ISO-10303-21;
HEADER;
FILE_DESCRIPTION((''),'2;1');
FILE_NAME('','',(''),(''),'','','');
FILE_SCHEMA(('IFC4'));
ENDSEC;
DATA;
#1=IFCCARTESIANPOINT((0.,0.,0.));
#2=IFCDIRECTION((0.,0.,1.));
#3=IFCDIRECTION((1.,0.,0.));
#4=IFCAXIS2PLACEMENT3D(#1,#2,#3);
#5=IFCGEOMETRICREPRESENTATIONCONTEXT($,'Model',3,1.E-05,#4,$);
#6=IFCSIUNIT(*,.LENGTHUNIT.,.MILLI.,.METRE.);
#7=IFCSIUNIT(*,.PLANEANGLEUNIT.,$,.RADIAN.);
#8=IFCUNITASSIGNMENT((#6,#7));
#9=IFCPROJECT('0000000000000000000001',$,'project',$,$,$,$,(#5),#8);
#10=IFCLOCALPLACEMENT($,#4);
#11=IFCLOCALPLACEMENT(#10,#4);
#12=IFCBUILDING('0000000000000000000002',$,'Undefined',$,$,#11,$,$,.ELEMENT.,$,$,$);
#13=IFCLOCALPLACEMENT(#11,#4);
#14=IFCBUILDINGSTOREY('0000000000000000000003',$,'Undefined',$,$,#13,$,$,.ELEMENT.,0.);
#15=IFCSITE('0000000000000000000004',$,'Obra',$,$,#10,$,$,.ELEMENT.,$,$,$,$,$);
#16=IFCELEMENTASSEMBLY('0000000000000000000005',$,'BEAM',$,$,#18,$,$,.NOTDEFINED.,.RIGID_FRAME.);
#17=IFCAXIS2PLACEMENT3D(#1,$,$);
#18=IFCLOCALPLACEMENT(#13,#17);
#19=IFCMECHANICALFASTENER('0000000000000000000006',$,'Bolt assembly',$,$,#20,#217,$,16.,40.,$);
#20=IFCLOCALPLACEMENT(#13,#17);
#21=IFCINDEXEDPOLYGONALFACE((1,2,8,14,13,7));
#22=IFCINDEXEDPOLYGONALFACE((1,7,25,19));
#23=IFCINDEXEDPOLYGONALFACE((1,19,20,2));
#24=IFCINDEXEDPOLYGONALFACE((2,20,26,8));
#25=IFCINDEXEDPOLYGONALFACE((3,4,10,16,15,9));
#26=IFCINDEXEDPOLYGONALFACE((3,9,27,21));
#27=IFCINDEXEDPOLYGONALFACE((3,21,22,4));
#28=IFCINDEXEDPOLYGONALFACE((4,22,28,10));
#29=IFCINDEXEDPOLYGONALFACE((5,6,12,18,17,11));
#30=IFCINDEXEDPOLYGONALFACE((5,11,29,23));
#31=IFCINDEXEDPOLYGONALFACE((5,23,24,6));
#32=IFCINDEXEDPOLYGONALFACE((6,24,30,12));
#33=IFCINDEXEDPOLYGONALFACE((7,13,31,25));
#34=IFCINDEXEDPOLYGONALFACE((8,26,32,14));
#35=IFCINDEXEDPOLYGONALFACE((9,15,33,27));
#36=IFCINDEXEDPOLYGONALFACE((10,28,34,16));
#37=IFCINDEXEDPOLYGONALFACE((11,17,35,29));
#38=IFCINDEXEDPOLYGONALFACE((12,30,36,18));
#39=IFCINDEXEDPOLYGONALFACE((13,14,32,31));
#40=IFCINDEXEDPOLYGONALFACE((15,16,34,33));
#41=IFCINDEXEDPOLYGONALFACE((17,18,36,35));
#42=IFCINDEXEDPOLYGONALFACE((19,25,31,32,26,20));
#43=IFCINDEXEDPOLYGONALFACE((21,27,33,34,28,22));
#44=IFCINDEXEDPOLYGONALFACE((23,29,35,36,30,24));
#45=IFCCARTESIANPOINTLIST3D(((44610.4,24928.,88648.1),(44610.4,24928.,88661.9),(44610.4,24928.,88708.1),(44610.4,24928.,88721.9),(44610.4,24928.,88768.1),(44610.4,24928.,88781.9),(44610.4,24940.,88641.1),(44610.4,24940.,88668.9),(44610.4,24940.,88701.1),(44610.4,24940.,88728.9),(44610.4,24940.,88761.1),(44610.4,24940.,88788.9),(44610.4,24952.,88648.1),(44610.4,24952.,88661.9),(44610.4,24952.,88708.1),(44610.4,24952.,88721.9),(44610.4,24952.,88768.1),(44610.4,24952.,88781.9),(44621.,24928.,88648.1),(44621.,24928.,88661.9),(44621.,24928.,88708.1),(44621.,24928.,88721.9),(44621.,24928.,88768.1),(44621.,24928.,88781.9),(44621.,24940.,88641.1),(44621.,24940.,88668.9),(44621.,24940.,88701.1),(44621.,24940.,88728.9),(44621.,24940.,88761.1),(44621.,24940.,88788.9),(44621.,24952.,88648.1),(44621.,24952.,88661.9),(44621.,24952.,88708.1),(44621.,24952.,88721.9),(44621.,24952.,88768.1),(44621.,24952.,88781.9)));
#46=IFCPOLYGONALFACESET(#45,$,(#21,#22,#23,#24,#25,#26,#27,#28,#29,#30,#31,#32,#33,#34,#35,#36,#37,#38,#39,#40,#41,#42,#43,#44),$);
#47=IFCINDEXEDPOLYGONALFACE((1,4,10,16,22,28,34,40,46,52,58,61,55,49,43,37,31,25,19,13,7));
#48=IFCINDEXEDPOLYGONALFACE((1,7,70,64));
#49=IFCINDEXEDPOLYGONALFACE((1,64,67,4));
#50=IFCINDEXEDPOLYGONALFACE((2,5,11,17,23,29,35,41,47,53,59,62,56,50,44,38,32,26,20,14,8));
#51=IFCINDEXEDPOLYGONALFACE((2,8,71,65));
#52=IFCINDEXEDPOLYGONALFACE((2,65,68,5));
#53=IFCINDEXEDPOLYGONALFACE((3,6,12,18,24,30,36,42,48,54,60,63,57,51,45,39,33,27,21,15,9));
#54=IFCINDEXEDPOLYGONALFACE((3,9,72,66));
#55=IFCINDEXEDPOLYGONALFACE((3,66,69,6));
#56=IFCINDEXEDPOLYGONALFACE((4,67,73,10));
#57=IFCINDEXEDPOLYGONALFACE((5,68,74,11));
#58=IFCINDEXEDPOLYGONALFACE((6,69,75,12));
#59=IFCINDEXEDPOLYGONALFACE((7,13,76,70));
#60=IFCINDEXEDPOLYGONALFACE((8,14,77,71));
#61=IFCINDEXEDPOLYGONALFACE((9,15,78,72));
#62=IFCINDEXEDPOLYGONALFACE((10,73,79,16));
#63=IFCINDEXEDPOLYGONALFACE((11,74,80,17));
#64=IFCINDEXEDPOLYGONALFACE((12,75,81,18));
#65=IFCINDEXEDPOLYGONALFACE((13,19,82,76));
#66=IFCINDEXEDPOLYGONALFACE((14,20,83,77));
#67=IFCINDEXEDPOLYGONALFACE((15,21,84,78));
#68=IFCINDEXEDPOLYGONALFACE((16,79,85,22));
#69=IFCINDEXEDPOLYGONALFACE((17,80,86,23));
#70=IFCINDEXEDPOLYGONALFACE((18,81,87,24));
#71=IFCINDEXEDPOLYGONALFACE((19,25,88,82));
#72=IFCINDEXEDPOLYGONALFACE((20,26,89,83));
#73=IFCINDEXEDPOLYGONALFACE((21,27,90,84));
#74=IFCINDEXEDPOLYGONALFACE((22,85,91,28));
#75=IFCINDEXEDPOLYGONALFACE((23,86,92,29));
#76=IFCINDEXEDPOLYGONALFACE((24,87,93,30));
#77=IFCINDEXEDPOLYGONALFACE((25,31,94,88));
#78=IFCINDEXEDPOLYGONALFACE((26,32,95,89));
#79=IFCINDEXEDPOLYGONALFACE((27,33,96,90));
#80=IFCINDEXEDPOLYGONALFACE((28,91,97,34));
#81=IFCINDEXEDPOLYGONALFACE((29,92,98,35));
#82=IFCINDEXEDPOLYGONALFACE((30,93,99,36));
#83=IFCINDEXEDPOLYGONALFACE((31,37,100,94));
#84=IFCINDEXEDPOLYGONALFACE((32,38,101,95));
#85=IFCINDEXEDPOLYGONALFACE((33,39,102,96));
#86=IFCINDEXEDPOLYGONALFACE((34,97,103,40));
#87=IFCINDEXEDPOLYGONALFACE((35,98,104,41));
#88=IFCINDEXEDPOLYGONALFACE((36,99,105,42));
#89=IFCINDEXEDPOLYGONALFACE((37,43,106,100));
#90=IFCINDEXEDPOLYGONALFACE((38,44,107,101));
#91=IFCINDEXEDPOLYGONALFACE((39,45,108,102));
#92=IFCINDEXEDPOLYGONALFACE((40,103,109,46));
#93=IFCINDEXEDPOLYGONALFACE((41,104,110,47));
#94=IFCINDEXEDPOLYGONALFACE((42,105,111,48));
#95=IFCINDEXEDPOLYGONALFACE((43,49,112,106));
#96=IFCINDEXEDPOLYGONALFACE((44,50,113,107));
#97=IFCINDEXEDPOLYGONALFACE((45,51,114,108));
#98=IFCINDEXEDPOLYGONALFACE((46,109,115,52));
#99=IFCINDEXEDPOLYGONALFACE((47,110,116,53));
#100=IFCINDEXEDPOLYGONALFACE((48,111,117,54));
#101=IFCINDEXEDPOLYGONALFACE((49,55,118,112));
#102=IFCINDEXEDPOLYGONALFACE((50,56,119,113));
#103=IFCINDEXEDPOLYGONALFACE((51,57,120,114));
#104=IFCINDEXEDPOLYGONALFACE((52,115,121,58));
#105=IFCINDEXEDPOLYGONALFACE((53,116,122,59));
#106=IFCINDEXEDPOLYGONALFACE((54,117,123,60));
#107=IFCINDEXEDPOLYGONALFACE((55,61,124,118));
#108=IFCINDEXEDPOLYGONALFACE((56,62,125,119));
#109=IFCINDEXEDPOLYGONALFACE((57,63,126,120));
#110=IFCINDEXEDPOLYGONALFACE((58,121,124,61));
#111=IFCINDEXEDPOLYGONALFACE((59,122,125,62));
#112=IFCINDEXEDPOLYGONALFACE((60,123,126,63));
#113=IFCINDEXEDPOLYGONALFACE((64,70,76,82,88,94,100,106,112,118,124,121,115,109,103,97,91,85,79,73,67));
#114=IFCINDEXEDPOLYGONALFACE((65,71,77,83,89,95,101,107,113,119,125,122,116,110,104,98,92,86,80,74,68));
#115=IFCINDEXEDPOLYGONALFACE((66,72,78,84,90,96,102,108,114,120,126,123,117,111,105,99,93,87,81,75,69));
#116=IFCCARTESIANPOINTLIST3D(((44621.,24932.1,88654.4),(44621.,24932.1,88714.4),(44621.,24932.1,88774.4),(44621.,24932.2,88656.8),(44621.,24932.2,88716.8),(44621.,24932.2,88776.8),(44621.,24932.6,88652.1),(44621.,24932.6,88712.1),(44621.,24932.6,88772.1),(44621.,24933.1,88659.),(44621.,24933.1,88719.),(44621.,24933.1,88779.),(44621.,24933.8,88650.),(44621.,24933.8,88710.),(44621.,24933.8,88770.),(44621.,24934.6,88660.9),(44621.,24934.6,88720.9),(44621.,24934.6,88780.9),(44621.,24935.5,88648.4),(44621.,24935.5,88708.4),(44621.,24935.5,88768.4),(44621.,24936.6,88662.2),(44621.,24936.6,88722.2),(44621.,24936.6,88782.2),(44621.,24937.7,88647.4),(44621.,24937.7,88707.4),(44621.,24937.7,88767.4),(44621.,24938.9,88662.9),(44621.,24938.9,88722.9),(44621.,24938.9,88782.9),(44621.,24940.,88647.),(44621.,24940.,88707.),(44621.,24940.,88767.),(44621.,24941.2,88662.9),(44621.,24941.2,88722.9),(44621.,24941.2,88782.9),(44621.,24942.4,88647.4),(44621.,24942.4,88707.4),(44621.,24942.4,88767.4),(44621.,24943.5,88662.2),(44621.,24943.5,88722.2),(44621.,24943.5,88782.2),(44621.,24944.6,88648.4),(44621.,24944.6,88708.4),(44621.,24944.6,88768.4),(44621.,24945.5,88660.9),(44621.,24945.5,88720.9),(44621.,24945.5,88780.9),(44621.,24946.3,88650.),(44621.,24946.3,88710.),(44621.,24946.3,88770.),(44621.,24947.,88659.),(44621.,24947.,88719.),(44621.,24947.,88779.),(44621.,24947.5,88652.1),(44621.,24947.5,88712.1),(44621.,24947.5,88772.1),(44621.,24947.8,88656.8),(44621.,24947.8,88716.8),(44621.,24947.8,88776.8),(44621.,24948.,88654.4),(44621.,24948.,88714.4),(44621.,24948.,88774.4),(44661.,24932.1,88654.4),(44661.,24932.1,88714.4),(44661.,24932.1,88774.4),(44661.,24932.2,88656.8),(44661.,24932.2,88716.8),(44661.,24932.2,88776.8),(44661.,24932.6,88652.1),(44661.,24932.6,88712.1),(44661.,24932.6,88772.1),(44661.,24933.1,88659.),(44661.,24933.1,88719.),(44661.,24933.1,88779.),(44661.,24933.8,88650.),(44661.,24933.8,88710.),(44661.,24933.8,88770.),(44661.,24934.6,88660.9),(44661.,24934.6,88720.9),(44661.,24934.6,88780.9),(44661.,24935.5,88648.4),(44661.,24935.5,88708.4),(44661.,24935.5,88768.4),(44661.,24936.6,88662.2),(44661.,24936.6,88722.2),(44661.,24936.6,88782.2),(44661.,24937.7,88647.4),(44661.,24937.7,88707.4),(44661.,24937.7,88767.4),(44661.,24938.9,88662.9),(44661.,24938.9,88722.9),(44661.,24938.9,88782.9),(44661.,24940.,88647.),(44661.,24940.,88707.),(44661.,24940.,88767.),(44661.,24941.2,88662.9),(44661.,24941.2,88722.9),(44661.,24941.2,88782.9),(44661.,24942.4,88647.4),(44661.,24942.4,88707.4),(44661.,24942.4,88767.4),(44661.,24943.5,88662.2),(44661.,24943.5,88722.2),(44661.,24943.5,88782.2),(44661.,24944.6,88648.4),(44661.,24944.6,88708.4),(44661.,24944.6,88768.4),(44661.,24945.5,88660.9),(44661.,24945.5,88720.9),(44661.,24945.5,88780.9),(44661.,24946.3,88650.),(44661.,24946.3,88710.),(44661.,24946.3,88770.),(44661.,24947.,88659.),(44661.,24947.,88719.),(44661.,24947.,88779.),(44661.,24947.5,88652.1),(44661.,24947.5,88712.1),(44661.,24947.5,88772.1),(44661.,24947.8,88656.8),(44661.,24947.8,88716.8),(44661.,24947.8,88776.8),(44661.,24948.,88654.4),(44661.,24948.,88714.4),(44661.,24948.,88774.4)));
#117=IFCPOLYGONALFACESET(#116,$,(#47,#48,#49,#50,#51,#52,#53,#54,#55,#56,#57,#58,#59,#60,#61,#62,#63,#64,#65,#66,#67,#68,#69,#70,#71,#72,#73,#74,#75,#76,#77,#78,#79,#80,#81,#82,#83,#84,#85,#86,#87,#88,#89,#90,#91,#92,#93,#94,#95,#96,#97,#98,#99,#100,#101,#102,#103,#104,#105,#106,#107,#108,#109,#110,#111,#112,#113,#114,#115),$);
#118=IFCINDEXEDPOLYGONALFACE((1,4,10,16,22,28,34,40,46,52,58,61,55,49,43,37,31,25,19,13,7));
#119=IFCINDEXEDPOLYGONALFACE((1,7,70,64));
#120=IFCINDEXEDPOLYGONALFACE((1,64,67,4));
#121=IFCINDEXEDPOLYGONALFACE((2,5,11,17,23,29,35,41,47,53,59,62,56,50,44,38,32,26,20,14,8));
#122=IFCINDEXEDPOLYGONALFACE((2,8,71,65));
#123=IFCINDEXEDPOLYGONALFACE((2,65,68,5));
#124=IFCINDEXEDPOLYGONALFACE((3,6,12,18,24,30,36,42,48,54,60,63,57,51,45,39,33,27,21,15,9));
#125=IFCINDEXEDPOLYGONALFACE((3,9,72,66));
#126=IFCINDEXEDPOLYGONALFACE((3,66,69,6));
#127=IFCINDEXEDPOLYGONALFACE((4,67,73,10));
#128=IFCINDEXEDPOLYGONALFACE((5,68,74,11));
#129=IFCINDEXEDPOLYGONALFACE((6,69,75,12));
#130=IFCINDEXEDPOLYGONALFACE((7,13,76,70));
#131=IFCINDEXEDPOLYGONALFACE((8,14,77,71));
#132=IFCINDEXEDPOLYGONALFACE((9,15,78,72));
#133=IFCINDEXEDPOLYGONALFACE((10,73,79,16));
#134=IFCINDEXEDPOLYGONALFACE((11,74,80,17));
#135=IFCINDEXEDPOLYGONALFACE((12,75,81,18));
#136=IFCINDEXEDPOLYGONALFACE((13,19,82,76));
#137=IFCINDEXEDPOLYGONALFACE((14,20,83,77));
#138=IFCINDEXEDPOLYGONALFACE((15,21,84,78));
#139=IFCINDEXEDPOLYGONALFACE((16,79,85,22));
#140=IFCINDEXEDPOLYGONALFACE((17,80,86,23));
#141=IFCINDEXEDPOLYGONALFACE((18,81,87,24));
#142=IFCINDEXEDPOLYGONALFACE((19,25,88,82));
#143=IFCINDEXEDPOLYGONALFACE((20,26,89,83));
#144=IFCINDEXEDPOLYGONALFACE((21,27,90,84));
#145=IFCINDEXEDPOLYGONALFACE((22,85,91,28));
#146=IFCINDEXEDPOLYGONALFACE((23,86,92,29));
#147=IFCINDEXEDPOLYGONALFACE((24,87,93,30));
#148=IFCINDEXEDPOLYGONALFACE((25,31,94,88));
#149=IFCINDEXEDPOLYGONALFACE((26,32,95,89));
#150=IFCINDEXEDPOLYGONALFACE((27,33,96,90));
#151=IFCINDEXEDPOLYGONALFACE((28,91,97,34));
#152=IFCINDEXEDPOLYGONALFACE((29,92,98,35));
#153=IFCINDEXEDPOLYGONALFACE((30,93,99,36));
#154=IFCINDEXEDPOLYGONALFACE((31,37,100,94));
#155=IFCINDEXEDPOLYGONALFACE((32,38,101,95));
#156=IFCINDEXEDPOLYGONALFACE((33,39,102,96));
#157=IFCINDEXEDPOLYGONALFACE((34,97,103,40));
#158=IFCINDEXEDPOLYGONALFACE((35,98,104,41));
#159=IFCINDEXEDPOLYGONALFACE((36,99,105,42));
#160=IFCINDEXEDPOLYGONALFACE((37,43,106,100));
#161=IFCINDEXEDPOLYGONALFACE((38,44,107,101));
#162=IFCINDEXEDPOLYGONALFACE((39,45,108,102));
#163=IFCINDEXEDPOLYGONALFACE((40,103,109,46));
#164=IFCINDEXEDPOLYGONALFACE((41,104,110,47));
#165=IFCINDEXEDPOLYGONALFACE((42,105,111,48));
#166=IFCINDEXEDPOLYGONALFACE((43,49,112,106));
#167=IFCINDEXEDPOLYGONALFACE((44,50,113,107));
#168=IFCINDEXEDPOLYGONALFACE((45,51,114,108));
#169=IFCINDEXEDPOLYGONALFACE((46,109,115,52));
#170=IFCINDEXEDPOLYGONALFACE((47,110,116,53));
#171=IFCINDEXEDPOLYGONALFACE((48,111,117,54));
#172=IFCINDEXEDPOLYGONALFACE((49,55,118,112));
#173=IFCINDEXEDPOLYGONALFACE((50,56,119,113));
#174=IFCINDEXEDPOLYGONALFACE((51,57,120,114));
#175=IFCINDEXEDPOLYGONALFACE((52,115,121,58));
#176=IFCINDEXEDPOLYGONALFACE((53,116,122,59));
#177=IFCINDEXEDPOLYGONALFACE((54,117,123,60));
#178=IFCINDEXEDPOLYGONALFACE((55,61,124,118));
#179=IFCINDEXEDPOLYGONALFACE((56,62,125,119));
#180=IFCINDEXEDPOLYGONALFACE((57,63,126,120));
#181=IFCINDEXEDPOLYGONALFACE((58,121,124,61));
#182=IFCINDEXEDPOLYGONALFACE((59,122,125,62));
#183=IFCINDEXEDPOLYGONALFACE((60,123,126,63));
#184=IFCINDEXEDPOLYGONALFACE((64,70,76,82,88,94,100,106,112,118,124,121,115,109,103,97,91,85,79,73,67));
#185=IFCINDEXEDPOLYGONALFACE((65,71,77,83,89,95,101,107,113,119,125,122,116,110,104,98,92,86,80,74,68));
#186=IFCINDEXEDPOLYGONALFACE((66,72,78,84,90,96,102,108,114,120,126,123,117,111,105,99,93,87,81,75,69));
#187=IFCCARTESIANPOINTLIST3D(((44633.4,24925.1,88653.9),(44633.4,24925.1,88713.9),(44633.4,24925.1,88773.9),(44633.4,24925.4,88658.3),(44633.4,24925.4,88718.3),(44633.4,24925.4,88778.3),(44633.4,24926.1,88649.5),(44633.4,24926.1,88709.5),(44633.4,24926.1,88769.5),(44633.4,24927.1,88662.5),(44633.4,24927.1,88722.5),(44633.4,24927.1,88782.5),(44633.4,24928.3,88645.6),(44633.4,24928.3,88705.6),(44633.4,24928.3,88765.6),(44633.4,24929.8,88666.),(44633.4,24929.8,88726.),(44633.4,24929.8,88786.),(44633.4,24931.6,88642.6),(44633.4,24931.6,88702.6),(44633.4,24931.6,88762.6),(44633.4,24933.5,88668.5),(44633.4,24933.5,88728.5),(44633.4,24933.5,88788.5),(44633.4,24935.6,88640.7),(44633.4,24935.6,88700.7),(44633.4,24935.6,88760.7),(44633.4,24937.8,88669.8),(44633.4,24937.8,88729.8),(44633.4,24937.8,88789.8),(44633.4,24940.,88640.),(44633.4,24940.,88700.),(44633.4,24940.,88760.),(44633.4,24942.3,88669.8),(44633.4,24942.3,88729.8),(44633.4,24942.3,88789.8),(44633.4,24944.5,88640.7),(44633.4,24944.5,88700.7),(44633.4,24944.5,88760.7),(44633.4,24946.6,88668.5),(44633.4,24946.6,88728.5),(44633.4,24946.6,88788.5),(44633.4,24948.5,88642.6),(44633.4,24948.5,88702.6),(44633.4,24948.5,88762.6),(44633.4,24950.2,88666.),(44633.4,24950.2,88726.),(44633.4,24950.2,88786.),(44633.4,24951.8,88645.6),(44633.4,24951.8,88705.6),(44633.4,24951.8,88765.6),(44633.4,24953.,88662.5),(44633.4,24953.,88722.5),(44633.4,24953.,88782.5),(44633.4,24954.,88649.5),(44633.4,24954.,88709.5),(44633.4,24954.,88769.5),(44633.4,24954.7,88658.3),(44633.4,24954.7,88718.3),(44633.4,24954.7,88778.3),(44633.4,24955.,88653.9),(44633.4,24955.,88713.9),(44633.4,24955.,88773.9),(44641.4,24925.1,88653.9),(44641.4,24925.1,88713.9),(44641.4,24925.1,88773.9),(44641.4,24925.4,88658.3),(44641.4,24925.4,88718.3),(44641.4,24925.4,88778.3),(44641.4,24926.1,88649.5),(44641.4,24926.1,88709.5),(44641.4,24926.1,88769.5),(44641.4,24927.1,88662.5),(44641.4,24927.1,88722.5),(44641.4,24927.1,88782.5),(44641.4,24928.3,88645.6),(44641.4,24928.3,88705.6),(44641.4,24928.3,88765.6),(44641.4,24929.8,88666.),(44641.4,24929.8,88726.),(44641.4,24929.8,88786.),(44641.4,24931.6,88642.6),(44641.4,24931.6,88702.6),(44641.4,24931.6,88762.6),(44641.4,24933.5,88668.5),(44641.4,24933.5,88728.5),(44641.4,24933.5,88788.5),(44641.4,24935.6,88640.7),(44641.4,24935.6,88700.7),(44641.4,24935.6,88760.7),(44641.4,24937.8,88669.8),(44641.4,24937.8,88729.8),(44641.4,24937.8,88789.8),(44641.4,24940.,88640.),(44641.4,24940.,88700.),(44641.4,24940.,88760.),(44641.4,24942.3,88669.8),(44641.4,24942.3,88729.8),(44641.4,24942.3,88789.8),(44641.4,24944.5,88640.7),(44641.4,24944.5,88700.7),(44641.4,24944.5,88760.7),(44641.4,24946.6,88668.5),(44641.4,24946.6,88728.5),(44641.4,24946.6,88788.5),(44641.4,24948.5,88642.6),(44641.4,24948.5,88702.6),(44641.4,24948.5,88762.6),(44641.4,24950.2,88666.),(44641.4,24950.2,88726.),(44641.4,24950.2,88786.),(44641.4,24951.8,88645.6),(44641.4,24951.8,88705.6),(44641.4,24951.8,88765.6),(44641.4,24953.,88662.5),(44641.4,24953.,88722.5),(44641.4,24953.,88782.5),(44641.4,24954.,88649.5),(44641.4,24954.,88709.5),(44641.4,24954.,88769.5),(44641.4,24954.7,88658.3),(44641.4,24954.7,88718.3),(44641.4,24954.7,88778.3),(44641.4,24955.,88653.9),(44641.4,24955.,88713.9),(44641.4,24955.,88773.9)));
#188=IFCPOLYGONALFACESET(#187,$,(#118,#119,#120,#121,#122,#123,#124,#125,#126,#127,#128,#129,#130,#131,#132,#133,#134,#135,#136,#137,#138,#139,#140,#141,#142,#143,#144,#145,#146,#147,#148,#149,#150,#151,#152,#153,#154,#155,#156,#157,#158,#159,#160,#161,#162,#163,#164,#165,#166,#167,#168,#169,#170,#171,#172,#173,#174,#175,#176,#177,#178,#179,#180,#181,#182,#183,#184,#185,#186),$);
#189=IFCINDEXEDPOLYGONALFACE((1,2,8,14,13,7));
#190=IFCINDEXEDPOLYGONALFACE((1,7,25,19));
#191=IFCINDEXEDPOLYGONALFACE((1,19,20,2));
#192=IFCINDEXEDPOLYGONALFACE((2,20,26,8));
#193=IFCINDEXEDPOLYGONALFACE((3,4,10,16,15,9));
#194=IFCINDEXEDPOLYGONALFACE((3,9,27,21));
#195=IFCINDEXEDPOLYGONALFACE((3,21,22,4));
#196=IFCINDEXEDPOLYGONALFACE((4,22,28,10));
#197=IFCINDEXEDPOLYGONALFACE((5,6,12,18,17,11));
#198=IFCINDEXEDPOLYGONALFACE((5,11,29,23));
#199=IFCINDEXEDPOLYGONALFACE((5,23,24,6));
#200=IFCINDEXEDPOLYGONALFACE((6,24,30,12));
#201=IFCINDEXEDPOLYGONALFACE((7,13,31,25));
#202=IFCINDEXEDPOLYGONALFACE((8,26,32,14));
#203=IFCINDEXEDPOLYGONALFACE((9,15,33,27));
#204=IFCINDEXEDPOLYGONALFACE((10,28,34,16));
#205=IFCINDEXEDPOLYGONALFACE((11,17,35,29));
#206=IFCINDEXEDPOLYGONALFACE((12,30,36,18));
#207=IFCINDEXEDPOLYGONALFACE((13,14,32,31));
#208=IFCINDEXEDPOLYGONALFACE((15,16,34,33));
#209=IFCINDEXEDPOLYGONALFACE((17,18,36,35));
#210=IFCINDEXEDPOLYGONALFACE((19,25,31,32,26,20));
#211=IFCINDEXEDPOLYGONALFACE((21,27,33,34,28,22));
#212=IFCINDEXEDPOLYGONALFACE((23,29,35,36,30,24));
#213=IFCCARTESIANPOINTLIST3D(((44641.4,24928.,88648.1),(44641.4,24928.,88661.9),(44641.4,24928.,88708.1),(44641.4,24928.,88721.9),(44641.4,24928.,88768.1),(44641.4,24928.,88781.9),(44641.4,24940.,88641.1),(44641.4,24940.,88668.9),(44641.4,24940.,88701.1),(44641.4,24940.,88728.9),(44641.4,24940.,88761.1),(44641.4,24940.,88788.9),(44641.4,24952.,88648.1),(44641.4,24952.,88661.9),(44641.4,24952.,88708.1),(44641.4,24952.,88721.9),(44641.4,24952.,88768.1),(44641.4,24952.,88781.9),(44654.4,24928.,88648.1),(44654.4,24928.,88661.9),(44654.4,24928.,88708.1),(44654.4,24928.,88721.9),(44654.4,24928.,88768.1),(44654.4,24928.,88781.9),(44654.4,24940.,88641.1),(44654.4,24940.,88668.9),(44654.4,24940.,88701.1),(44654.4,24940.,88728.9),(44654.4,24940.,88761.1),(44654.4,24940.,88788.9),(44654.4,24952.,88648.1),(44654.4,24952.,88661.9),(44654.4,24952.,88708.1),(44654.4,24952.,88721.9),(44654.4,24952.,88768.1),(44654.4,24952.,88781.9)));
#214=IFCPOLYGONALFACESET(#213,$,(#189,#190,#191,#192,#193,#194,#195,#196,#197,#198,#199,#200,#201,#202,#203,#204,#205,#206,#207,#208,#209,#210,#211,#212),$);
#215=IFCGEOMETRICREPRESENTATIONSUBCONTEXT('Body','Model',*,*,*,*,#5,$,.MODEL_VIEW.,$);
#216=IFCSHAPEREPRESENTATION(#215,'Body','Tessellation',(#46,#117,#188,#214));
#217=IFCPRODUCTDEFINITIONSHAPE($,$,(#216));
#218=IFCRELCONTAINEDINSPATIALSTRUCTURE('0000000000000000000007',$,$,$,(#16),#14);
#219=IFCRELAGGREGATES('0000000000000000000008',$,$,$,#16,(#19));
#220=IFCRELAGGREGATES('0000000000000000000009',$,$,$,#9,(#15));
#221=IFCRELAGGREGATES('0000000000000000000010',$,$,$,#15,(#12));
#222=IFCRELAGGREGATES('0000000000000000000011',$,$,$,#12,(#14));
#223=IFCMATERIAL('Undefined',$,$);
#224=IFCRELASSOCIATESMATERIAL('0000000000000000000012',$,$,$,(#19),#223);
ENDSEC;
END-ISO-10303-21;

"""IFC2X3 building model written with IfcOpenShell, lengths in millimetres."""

from ifc_helpers import new_model, si_unit, frame, origin_with_axes, origin_2d_with_axis, place, context, subcontext, project, spatial, polyline, circle, outline, extrude, source, transform, mapped, material, element, aggregate, save


model = new_model("IFC2X3")

# Units and contexts
model_context = context("Model", 3, precision=1e-05, world=origin_with_axes())
body_context = subcontext(model_context, "Body", "Model", "MODEL_VIEW")
ifc_project = project(units=[si_unit("LENGTHUNIT", "METRE", prefix="MILLI"), si_unit("PLANEANGLEUNIT", "RADIAN")], contexts=[model_context])

# Site, building, storey
site_placement = place(None, origin_with_axes())
site = spatial("IfcSite", under=ifc_project, at=site_placement, Name="Obra", CompositionType="ELEMENT")
building_placement = place(site_placement, origin_with_axes())
building = spatial("IfcBuilding", under=site, at=building_placement, Name="Undefined", CompositionType="ELEMENT")
storey_placement = place(building_placement, origin_with_axes())
storey = spatial("IfcBuildingStorey", under=building, at=storey_placement, Name="Undefined", CompositionType="ELEMENT", Elevation=0.0)

# Element assembly
ifc_material_1 = material(Name="Undefined")
assembly_1_placement = place(storey_placement, origin_with_axes())
assembly_1 = element("IfcElementAssembly", 1, at=assembly_1_placement, inside=storey, Name="BEAM", AssemblyPlace="NOTDEFINED", PredefinedType="RIGID_FRAME")
shared_shape_1 = source(origin_with_axes(), body_context, "Body", "SweptSolid", [
    extrude(outline(polyline([(13.9, 0.0), (6.9, 12.0), (-6.9, 12.0), (-13.9, 0.0), (-6.9, -12.0), (6.9, -12.0), (13.9, 0.0)])), frame((0.0, -19.7, 0.0), z_axis=(0.0, 1.0, 0.0), x_axis=(1.0, 0.0, 0.0)), (0.0, 0.0, 1.0), 10.6),
    extrude(circle(Radius=8.0, at=origin_2d_with_axis()), frame((0.0, -9.1, 0.0), z_axis=(0.0, 1.0, 0.0), x_axis=(1.0, 0.0, 0.0)), (0.0, 0.0, 1.0), 40.0),
    extrude(circle(Radius=15.0, at=origin_2d_with_axis()), frame((0.0, 3.3, 0.0), z_axis=(0.0, 1.0, 0.0), x_axis=(1.0, 0.0, 0.0)), (0.0, 0.0, 1.0), 8.0),
    extrude(outline(polyline([(13.9, 0.0), (6.9, 12.0), (-6.9, 12.0), (-13.9, 0.0), (-6.9, -12.0), (6.9, -12.0), (13.9, 0.0)])), frame((0.0, 11.3, 0.0), z_axis=(0.0, 1.0, 0.0), x_axis=(1.0, 0.0, 0.0)), (0.0, 0.0, 1.0), 13.0),
])

# Mechanical fastener
mechanical_fastener_1_placement = place(assembly_1_placement, frame((44630.1, 24990.0, 88835.0), z_axis=(0.000002, -1.0, 0.0), x_axis=(0.0, 0.0, -1.0)))
mechanical_fastener_1 = element("IfcMechanicalFastener", 2, at=mechanical_fastener_1_placement, material=ifc_material_1, Name="Bolt assembly", NominalDiameter=16.0, NominalLength=40.0, context=body_context, shape_type="MappedRepresentation", body=[
    mapped(shared_shape_1, transform((60.0, 0.0, 50.0))),
    mapped(shared_shape_1, transform((120.0, 0.0, 50.0))),
    mapped(shared_shape_1, transform((180.0, 0.0, 50.0))),
])
aggregate(assembly_1, [mechanical_fastener_1])

save(model, "model.ifc")
